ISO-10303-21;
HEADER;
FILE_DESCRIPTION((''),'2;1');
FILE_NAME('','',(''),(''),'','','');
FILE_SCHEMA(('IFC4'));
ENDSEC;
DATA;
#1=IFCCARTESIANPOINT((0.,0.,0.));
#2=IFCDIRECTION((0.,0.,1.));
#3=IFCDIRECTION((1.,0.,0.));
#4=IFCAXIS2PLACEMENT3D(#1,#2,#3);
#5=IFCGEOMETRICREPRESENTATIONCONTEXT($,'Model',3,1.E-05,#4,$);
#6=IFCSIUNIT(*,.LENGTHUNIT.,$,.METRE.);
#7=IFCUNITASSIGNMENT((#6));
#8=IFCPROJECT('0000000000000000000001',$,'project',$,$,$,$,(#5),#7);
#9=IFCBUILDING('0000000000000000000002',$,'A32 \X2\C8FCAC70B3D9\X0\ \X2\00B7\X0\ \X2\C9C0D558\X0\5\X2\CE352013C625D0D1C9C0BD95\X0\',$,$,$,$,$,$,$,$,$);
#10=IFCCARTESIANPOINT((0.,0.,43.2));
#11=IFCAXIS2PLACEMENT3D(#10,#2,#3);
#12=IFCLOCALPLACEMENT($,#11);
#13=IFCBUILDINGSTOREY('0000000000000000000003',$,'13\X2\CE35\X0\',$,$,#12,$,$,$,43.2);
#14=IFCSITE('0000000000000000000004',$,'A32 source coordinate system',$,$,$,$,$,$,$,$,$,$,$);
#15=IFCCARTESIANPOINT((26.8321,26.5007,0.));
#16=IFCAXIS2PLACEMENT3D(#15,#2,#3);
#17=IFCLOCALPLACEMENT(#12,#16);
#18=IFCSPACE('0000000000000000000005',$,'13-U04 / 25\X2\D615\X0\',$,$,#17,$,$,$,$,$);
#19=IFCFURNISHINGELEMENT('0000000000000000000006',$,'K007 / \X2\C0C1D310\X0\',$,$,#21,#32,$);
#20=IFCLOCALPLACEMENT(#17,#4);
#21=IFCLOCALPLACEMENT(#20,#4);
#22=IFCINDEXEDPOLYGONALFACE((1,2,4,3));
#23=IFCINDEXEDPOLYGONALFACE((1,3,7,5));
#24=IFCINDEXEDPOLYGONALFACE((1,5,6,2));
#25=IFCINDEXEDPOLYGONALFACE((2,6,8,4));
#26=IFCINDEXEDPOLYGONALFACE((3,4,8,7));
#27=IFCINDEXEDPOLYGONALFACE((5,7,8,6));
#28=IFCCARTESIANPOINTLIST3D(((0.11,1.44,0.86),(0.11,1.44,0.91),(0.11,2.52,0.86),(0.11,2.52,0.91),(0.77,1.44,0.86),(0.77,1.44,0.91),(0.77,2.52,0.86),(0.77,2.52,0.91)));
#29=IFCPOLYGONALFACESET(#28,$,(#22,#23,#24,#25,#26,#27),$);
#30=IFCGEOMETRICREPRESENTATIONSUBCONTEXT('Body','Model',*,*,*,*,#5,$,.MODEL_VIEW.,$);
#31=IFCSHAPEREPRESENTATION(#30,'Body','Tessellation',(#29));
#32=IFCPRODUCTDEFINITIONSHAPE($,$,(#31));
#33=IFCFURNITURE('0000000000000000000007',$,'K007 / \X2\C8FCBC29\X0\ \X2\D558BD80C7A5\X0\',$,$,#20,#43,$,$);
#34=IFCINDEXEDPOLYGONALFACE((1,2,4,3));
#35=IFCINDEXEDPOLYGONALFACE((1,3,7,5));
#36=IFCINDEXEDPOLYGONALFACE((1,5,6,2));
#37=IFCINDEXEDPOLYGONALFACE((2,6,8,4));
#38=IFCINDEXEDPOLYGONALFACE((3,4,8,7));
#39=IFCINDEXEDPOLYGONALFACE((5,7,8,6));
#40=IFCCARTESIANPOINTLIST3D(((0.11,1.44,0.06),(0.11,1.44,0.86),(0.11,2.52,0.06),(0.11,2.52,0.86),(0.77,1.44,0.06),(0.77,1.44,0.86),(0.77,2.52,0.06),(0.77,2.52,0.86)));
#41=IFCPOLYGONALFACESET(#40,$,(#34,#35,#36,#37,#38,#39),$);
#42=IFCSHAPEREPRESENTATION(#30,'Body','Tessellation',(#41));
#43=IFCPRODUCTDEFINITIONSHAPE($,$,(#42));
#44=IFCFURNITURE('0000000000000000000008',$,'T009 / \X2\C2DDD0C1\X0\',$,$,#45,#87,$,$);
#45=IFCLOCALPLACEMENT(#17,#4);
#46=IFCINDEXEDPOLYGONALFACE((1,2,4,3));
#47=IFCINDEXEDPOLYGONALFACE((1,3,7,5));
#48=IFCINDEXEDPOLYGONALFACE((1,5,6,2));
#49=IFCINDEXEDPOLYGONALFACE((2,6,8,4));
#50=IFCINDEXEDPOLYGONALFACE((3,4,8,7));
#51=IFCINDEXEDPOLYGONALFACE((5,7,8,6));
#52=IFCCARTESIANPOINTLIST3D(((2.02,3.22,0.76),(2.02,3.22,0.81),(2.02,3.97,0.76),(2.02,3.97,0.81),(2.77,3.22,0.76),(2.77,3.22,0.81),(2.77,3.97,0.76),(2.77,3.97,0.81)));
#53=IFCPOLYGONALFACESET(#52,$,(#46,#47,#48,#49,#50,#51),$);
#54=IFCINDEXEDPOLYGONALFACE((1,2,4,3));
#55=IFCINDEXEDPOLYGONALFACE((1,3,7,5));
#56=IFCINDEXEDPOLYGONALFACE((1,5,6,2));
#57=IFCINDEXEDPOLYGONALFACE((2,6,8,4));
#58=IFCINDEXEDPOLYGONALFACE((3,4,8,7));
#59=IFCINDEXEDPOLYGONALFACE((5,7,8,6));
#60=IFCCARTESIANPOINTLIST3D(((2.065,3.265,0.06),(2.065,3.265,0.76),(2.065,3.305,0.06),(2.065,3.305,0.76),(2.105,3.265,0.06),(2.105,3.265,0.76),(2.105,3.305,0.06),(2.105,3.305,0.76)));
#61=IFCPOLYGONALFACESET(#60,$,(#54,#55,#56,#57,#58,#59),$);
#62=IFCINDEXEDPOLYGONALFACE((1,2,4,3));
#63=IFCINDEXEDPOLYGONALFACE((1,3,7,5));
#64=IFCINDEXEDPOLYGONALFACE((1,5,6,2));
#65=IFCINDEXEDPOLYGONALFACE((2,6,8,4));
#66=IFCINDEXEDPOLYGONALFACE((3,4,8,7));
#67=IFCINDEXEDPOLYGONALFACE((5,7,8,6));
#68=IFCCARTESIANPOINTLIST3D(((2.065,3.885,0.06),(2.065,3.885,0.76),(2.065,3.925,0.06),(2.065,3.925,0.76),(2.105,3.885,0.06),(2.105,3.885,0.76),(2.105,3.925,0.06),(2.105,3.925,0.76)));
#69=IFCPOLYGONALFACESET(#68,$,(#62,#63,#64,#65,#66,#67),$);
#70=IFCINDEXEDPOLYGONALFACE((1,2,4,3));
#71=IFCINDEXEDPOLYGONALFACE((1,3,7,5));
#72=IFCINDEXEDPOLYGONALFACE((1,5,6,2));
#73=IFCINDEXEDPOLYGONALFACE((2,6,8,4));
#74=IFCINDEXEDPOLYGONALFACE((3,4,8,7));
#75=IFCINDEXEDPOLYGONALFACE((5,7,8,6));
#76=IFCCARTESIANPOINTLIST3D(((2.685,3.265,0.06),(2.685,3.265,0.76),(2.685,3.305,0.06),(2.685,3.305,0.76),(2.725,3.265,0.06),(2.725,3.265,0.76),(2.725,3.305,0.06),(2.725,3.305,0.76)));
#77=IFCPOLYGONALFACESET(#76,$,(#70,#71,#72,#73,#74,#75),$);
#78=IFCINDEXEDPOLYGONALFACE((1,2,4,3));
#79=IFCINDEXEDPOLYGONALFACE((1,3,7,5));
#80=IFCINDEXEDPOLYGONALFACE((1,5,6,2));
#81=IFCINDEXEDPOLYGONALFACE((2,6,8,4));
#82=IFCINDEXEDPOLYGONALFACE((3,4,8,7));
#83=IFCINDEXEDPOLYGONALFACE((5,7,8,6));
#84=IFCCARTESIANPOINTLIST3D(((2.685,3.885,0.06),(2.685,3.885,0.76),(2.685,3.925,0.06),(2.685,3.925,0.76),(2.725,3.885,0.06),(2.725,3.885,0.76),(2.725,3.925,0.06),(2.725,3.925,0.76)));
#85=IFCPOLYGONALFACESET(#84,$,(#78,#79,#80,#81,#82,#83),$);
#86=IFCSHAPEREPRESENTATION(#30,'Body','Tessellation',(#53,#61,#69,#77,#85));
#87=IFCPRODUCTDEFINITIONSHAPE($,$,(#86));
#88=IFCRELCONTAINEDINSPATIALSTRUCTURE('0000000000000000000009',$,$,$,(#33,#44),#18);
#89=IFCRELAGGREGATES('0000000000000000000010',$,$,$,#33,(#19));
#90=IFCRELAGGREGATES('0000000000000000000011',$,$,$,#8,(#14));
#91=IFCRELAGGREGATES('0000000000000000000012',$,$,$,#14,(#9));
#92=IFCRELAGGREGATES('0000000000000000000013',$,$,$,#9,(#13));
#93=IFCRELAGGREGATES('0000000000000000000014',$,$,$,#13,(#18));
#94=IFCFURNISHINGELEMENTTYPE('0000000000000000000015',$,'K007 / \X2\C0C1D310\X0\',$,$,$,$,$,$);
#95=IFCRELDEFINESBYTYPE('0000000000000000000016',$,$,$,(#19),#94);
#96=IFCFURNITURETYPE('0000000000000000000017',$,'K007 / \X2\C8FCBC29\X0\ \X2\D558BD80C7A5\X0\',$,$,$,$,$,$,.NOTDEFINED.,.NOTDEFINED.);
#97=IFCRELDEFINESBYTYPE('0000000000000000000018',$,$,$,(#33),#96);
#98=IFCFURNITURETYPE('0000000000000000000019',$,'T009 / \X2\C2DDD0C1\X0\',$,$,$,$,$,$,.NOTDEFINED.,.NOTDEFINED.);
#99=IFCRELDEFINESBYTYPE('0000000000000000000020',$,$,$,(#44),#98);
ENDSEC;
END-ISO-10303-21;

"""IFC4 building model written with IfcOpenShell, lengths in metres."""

from ifc_helpers import new_model, si_unit, frame, origin, origin_with_axes, place, context, subcontext, project, spatial, polyline, outline, extrude, source, transform, mapped, type_object, type_shapes, element, aggregate, save


model = new_model("IFC4")

# Units and contexts
model_context = context("Model", 3, precision=1e-05, world=origin_with_axes())
body_context = subcontext(model_context, "Body", "Model", "MODEL_VIEW")
ifc_project = project(units=[si_unit("LENGTHUNIT", "METRE")], contexts=[model_context])

# Site, building, storey
site = spatial("IfcSite", under=ifc_project, Name="A32 source coordinate system")
building = spatial("IfcBuilding", under=site, Name="A32 주거동 · 지하5층–옥탑지붕")
storey_placement = place(None, frame((0.0, 0.0, 43.2), z_axis=(0.0, 0.0, 1.0), x_axis=(1.0, 0.0, 0.0)))
storey = spatial("IfcBuildingStorey", under=building, at=storey_placement, Name="13층", Elevation=43.2)

# Shared definitions
space_1_placement = place(storey_placement, frame((26.8321, 26.5007, 0.0), z_axis=(0.0, 0.0, 1.0), x_axis=(1.0, 0.0, 0.0)))
space_1 = spatial("IfcSpace", under=storey, at=space_1_placement, Name="13-U04 / 25형")

# Furnishing element
furnishing_element_type_1 = type_object("IfcFurnishingElementType", Name="K007 / 상판")
shared_shape_1 = source(origin(), body_context, "Body", "SweptSolid", [
    extrude(outline(polyline([(0.77, 2.52), (0.77, 1.44), (0.11, 1.44), (0.11, 2.52), (0.77, 2.52)])), frame((0.0, 0.0, 0.86)), (0.0, 0.0, 1.0), 0.05),
])
type_shapes(furnishing_element_type_1, [shared_shape_1])
furniture_1_placement = place(space_1_placement, origin_with_axes())
furnishing_1_placement = place(furniture_1_placement, origin_with_axes())
furnishing_1 = element("IfcFurnishingElement", 1, at=furnishing_1_placement, type_object=furnishing_element_type_1, Name="K007 / 상판", context=body_context, shape_type="MappedRepresentation", body=[
    mapped(shared_shape_1, transform((0.0, 0.0, 0.0), scale=1.0)),
])

# Furniture
furniture_type_1 = type_object("IfcFurnitureType", Name="K007 / 주방 하부장", AssemblyPlace="NOTDEFINED", PredefinedType="NOTDEFINED")
shared_shape_2 = source(origin(), body_context, "Body", "SweptSolid", [
    extrude(outline(polyline([(0.11, 2.52), (0.77, 2.52), (0.77, 1.44), (0.11, 1.44), (0.11, 2.52)])), frame((0.0, 0.0, 0.06)), (0.0, 0.0, 1.0), 0.8),
])
type_shapes(furniture_type_1, [shared_shape_2])
furniture_1 = element("IfcFurniture", 2, at=furniture_1_placement, inside=space_1, type_object=furniture_type_1, Name="K007 / 주방 하부장", context=body_context, shape_type="MappedRepresentation", body=[
    mapped(shared_shape_2, transform((0.0, 0.0, 0.0), scale=1.0)),
])
aggregate(furniture_1, [furnishing_1])
furniture_type_2 = type_object("IfcFurnitureType", Name="T009 / 식탁", AssemblyPlace="NOTDEFINED", PredefinedType="NOTDEFINED")
shared_shape_3 = source(origin(), body_context, "Body", "SweptSolid", [
    extrude(outline(polyline([(2.77, 3.22), (2.02, 3.22), (2.02, 3.97), (2.77, 3.97), (2.77, 3.22)])), frame((0.0, 0.0, 0.76)), (0.0, 0.0, 1.0), 0.05),
    extrude(outline(polyline([(2.065, 3.265), (2.065, 3.305), (2.105, 3.305), (2.105, 3.265), (2.065, 3.265)])), frame((0.0, 0.0, 0.06)), (0.0, 0.0, 1.0), 0.7),
    extrude(outline(polyline([(2.065, 3.885), (2.065, 3.925), (2.105, 3.925), (2.105, 3.885), (2.065, 3.885)])), frame((0.0, 0.0, 0.06)), (0.0, 0.0, 1.0), 0.7),
    extrude(outline(polyline([(2.685, 3.265), (2.685, 3.305), (2.725, 3.305), (2.725, 3.265), (2.685, 3.265)])), frame((0.0, 0.0, 0.06)), (0.0, 0.0, 1.0), 0.7),
    extrude(outline(polyline([(2.685, 3.885), (2.685, 3.925), (2.725, 3.925), (2.725, 3.885), (2.685, 3.885)])), frame((0.0, 0.0, 0.06)), (0.0, 0.0, 1.0), 0.7),
])
type_shapes(furniture_type_2, [shared_shape_3])
furniture_2_placement = place(space_1_placement, origin_with_axes())
element("IfcFurniture", 3, at=furniture_2_placement, inside=space_1, type_object=furniture_type_2, Name="T009 / 식탁", context=body_context, shape_type="MappedRepresentation", body=[
    mapped(shared_shape_3, transform((0.0, 0.0, 0.0), scale=1.0)),
])

save(model, "model.ifc")
